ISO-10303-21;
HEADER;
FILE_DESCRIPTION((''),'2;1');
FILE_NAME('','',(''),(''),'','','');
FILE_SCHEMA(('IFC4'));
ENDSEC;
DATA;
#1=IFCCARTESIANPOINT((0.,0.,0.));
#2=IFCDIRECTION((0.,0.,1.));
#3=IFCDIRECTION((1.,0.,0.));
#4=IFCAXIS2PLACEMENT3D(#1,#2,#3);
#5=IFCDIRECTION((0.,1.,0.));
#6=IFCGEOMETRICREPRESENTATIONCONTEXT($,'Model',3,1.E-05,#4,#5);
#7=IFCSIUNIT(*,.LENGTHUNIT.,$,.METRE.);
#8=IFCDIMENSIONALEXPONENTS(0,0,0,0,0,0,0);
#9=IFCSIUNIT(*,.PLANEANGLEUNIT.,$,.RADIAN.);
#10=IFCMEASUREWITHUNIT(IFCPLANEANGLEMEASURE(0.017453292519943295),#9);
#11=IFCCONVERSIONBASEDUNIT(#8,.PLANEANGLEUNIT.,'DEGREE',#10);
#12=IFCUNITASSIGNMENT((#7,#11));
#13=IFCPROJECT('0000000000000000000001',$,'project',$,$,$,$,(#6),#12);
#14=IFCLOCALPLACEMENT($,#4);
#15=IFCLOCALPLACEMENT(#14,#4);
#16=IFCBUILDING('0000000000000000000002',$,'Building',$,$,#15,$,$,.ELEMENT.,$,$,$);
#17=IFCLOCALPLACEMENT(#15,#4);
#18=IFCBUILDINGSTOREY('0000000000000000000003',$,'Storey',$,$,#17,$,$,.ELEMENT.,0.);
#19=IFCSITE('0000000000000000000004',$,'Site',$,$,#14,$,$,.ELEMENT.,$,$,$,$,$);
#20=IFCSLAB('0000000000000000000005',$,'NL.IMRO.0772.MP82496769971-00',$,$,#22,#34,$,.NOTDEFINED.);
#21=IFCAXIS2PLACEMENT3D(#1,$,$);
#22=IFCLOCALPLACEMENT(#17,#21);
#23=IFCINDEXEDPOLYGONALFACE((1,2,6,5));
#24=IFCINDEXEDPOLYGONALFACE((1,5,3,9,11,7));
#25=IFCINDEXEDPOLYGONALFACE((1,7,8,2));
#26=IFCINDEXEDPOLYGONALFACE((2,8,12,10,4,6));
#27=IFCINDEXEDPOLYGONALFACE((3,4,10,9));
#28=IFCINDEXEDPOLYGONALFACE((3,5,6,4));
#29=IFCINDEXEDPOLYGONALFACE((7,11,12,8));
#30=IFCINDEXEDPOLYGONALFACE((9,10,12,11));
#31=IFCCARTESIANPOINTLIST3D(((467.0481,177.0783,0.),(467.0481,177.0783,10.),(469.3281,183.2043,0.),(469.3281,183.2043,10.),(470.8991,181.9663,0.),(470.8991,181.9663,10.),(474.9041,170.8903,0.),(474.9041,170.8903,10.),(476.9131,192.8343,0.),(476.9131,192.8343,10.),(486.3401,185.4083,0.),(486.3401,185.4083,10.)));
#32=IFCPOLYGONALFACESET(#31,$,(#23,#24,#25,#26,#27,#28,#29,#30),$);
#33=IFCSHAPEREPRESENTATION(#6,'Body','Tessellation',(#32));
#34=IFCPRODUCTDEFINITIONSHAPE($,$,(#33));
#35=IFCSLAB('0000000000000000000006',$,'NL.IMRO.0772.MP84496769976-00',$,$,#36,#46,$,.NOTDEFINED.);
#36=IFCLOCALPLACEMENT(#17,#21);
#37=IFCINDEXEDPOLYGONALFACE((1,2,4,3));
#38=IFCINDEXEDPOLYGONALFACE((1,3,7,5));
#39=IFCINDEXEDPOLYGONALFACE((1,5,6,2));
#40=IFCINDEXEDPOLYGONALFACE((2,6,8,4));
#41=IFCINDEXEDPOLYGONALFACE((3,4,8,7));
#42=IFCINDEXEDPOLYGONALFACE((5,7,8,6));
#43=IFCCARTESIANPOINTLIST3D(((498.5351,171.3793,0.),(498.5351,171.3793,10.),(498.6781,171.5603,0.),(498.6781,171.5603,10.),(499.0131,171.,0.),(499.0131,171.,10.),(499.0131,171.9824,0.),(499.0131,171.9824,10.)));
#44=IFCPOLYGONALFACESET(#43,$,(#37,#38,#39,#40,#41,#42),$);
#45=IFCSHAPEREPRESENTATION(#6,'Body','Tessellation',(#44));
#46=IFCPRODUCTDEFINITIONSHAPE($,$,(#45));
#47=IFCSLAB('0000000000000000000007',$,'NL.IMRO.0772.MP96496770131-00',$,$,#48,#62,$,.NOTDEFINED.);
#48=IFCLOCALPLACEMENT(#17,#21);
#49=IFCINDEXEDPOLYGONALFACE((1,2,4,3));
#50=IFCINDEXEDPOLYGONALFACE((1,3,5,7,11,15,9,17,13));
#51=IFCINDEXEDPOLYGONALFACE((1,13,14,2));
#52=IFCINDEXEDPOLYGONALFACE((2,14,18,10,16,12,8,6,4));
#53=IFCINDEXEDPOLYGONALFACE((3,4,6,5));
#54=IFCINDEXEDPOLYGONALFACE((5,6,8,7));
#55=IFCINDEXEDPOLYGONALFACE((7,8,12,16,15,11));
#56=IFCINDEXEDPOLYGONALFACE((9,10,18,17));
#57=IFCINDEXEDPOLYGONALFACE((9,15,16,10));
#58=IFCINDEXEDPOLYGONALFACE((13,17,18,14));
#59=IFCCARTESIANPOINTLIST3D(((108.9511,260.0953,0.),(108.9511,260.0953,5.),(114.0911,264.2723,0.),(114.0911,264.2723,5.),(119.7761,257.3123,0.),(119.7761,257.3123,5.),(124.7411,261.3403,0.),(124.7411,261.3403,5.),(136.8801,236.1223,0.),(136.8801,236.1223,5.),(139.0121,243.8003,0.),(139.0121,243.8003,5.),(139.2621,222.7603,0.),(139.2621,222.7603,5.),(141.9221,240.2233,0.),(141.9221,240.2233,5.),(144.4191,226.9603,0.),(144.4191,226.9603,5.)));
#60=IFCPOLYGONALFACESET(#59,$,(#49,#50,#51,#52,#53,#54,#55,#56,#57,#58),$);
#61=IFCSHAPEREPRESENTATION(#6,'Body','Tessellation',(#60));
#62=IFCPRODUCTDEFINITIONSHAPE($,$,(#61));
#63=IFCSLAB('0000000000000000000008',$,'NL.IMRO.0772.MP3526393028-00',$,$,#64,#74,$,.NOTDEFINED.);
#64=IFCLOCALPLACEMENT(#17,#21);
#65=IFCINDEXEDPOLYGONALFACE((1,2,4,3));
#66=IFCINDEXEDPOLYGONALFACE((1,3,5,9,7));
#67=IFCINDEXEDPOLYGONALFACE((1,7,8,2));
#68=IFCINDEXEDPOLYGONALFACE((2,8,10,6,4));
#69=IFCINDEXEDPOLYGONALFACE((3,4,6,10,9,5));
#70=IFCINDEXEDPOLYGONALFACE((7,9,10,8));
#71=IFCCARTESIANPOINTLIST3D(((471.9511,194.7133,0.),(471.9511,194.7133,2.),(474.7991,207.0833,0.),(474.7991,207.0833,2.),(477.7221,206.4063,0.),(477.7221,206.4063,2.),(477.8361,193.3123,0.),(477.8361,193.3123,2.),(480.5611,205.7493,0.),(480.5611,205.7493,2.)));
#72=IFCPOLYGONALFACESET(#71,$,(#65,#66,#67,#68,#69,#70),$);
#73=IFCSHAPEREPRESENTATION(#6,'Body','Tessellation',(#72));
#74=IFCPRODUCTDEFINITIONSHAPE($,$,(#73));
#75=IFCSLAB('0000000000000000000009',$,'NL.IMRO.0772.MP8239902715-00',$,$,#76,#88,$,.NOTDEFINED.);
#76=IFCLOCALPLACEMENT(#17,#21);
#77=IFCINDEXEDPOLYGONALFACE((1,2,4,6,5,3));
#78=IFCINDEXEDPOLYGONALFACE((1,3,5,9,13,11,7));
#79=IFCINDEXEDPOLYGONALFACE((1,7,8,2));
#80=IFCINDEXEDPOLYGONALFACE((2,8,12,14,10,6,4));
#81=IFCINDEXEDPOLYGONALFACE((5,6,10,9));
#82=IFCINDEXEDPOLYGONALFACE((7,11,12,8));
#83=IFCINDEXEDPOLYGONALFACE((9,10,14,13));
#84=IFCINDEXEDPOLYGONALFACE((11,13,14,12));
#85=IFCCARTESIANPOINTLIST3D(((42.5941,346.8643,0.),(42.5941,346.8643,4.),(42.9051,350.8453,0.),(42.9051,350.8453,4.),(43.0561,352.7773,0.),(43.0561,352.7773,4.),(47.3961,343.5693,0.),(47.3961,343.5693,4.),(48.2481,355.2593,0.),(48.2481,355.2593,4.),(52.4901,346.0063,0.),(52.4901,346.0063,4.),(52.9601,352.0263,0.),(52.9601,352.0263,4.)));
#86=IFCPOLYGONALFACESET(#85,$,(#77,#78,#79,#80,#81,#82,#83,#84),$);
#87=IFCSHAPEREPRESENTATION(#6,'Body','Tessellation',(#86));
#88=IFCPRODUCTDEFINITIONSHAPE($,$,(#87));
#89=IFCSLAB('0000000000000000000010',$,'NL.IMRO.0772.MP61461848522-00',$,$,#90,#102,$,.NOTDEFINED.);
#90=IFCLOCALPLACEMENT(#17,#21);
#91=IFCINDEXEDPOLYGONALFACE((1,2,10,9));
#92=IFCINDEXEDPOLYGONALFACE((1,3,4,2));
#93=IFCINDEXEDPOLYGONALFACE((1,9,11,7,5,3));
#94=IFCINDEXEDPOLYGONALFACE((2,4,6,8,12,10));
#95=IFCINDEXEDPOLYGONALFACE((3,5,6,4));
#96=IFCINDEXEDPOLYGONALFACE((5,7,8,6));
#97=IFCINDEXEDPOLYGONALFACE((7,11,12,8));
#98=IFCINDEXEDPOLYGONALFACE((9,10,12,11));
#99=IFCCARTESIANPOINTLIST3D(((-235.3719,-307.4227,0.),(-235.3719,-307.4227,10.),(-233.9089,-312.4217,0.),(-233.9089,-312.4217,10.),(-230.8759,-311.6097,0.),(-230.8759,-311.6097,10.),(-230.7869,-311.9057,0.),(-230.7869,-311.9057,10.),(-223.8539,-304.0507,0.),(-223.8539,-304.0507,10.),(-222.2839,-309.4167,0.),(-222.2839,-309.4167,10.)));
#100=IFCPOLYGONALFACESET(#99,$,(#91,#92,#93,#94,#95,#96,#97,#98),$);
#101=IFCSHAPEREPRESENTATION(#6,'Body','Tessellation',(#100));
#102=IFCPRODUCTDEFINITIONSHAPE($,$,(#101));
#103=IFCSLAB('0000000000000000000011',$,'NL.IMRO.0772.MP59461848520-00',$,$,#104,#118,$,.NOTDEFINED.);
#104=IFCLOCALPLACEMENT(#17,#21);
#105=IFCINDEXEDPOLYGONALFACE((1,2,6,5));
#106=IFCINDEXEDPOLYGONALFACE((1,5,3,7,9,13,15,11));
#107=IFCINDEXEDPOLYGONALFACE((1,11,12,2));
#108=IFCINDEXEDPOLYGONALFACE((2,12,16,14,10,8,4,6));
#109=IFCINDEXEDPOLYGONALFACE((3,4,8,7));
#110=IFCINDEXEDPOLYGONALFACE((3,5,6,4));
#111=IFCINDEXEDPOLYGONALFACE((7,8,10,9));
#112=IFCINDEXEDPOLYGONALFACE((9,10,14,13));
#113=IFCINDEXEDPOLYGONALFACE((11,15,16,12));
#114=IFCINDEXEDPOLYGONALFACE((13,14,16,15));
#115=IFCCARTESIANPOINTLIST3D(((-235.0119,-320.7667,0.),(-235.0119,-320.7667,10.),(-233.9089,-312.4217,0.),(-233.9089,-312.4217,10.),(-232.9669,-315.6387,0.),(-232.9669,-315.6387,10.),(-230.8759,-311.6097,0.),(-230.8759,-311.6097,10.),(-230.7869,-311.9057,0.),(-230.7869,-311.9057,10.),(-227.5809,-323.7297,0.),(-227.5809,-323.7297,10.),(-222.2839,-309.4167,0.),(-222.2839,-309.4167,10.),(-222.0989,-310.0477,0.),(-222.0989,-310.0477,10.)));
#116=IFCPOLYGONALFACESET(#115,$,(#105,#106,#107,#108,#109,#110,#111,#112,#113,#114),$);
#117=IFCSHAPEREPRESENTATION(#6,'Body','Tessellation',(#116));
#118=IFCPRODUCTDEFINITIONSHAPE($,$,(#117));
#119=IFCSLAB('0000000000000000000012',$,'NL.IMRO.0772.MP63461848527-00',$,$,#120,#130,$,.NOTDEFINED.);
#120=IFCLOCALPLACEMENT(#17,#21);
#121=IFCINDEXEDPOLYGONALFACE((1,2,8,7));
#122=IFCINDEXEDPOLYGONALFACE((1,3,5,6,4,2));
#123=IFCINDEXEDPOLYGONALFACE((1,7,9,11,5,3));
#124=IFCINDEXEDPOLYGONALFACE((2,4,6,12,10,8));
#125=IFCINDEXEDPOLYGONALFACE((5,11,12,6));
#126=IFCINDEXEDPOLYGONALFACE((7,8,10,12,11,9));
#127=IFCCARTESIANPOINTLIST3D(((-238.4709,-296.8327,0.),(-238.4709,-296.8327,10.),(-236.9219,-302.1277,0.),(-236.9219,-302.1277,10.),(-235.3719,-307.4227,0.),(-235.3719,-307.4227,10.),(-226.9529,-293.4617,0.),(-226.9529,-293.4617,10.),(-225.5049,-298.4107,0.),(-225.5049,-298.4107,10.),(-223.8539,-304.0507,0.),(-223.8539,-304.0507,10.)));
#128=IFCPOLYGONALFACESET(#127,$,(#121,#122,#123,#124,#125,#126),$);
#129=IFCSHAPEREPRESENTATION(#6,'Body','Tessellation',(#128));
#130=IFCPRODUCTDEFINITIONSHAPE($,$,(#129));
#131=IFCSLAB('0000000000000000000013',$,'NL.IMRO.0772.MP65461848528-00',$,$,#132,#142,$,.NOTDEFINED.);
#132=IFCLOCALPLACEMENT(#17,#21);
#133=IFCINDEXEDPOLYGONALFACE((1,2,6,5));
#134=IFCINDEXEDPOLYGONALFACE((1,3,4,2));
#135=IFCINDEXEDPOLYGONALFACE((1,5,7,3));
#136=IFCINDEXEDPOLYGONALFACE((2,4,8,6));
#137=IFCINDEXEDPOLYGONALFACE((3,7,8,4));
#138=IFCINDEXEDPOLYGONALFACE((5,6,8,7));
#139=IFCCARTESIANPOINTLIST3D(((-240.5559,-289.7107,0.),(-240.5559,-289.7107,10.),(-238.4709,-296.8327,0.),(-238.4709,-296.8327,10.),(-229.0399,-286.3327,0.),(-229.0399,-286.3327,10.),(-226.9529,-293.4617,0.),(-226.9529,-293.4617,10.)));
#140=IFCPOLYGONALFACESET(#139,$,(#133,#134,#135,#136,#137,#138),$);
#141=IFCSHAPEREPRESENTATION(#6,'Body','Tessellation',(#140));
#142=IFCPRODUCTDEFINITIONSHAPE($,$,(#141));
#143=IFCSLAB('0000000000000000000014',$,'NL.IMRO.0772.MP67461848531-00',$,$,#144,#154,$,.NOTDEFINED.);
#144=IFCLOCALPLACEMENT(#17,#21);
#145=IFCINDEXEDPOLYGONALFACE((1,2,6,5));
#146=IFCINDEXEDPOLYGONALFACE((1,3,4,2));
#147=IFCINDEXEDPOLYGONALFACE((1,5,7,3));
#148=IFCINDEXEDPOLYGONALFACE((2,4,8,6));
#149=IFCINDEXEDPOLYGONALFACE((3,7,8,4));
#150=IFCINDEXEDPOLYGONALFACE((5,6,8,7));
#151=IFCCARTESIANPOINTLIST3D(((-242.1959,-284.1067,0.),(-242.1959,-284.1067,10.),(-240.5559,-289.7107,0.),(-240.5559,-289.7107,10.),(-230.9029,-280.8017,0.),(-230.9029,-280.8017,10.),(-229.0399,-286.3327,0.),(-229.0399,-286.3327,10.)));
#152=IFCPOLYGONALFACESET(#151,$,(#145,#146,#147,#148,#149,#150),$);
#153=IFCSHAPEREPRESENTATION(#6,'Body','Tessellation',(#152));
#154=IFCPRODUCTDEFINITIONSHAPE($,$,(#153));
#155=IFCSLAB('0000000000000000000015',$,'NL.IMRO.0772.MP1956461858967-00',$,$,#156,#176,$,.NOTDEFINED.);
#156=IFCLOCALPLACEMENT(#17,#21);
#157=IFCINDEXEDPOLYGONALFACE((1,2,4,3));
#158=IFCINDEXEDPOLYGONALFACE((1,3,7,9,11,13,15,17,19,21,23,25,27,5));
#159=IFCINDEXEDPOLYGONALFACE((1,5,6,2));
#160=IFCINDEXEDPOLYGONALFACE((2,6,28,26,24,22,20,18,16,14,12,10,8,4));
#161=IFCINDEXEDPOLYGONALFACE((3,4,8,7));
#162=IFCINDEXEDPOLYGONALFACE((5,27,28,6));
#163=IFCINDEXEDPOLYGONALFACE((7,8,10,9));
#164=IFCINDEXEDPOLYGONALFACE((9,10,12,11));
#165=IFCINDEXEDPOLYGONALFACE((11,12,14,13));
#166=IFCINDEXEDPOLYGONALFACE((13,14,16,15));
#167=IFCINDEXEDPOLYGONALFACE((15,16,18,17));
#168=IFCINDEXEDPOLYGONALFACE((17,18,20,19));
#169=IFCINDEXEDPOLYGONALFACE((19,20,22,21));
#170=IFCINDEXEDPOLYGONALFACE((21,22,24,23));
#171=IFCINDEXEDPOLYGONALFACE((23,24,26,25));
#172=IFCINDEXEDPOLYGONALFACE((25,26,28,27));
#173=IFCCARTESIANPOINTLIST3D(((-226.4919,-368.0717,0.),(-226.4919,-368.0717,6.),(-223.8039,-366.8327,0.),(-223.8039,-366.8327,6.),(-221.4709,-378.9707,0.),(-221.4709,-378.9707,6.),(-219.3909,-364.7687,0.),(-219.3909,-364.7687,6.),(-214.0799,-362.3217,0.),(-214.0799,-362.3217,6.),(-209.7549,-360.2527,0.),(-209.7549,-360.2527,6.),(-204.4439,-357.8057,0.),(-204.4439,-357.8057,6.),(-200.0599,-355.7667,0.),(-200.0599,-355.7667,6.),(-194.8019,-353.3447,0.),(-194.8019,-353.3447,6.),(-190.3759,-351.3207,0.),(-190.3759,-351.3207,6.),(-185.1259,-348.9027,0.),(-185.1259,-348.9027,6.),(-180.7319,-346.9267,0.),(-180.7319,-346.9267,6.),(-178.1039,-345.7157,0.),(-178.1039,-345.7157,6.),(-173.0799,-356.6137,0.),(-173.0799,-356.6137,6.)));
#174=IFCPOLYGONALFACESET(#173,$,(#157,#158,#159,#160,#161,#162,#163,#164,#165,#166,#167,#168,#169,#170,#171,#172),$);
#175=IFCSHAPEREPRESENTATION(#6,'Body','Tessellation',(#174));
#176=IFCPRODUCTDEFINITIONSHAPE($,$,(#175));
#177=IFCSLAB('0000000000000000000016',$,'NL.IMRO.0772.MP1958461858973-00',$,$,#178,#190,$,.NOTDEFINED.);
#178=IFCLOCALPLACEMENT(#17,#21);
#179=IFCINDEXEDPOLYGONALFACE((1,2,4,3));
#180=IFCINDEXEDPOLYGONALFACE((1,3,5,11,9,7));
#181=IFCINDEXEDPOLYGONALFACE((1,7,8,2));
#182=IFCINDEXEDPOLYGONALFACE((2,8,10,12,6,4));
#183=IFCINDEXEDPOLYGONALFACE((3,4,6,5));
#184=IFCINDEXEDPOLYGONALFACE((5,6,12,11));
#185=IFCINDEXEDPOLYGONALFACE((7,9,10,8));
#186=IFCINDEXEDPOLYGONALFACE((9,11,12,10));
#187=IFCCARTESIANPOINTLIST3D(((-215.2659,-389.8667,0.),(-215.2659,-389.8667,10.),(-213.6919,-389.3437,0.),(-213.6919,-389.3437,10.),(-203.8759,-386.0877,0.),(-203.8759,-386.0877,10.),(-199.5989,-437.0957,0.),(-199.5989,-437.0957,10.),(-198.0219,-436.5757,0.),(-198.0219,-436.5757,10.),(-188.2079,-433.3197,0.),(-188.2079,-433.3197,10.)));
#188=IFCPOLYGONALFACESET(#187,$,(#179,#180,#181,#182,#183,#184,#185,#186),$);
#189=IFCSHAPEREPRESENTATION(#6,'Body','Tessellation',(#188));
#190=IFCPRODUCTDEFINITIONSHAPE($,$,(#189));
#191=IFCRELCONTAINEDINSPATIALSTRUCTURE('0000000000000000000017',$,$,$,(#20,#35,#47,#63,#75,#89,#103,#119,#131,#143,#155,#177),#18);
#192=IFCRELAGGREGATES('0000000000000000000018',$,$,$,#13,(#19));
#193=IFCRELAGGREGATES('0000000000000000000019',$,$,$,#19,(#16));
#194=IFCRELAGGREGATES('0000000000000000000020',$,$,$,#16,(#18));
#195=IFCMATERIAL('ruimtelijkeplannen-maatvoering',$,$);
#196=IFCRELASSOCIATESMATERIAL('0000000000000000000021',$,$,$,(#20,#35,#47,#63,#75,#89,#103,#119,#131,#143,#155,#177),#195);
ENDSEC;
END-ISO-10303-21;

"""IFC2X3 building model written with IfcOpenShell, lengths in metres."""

from ifc_helpers import new_model, entity, si_unit, converted_unit, direction, origin_with_axes, place, context, project, spatial, polyline, outline, extrude, material, element, save


model = new_model("IFC2X3")

# Units and contexts
model_context = context("Model", 3, precision=1e-05, world=origin_with_axes(), true_north=direction((0.0, 1.0, 0.0)))
ifc_project = project(units=[si_unit("LENGTHUNIT", "METRE"), converted_unit("PLANEANGLEUNIT", "DEGREE", entity("IfcPlaneAngleMeasure", 0.017453292519943295), si_unit("PLANEANGLEUNIT", "RADIAN"), dimensions=[0, 0, 0, 0, 0, 0, 0])], contexts=[model_context])

# Site, building, storey
site_placement = place(None, origin_with_axes())
site = spatial("IfcSite", under=ifc_project, at=site_placement, Name="Site", CompositionType="ELEMENT")
building_placement = place(site_placement, origin_with_axes())
building = spatial("IfcBuilding", under=site, at=building_placement, Name="Building", CompositionType="ELEMENT")
storey_placement = place(building_placement, origin_with_axes())
storey = spatial("IfcBuildingStorey", under=building, at=storey_placement, Name="Storey", CompositionType="ELEMENT", Elevation=0.0)

# Slabs
ifc_material = material(Name="ruimtelijkeplannen-maatvoering")
slab_1_placement = place(storey_placement, origin_with_axes())
element("IfcSlab", 1, at=slab_1_placement, inside=storey, material=ifc_material, Name="NL.IMRO.0772.MP82496769971-00", PredefinedType="NOTDEFINED", context=model_context, shape_type="SweptSolid", body=[
    extrude(outline(polyline([(467.0481, 177.0783), (470.8991, 181.9663), (469.3281, 183.2043), (476.9131, 192.8343), (486.3401, 185.4083), (474.9041, 170.8903), (467.0481, 177.0783)])), origin_with_axes(), (0.0, 0.0, 1.0), 10.0),
])
slab_2_placement = place(storey_placement, origin_with_axes())
element("IfcSlab", 2, at=slab_2_placement, inside=storey, material=ifc_material, Name="NL.IMRO.0772.MP84496769976-00", PredefinedType="NOTDEFINED", context=model_context, shape_type="SweptSolid", body=[
    extrude(outline(polyline([(498.5351, 171.3793), (498.6781, 171.5603), (499.0131, 171.9824), (499.0131, 171.0), (498.5351, 171.3793)])), origin_with_axes(), (0.0, 0.0, 1.0), 10.0),
])
slab_3_placement = place(storey_placement, origin_with_axes())
element("IfcSlab", 3, at=slab_3_placement, inside=storey, material=ifc_material, Name="NL.IMRO.0772.MP96496770131-00", PredefinedType="NOTDEFINED", context=model_context, shape_type="SweptSolid", body=[
    extrude(outline(polyline([(141.9221, 240.2233), (136.8801, 236.1223), (144.4191, 226.9603), (139.2621, 222.7603), (108.9511, 260.0953), (114.0911, 264.2723), (119.7761, 257.3123), (124.7411, 261.3403), (139.0121, 243.8003), (141.9221, 240.2233)])), origin_with_axes(), (0.0, 0.0, 1.0), 5.0),
])
slab_4_placement = place(storey_placement, origin_with_axes())
element("IfcSlab", 4, at=slab_4_placement, inside=storey, material=ifc_material, Name="NL.IMRO.0772.MP3526393028-00", PredefinedType="NOTDEFINED", context=model_context, shape_type="SweptSolid", body=[
    extrude(outline(polyline([(474.7991, 207.0833), (477.7221, 206.4063), (480.5611, 205.7493), (477.8361, 193.3123), (471.9511, 194.7133), (474.7991, 207.0833)])), origin_with_axes(), (0.0, 0.0, 1.0), 2.0),
])
slab_5_placement = place(storey_placement, origin_with_axes())
element("IfcSlab", 5, at=slab_5_placement, inside=storey, material=ifc_material, Name="NL.IMRO.0772.MP8239902715-00", PredefinedType="NOTDEFINED", context=model_context, shape_type="SweptSolid", body=[
    extrude(outline(polyline([(48.2481, 355.2593), (52.9601, 352.0263), (52.4901, 346.0063), (47.3961, 343.5693), (42.5941, 346.8643), (42.9051, 350.8453), (43.0561, 352.7773), (48.2481, 355.2593)])), origin_with_axes(), (0.0, 0.0, 1.0), 4.0),
])
slab_6_placement = place(storey_placement, origin_with_axes())
element("IfcSlab", 6, at=slab_6_placement, inside=storey, material=ifc_material, Name="NL.IMRO.0772.MP61461848522-00", PredefinedType="NOTDEFINED", context=model_context, shape_type="SweptSolid", body=[
    extrude(outline(polyline([(-233.9089, -312.4217), (-235.3719, -307.4227), (-223.8539, -304.0507), (-222.2839, -309.4167), (-230.7869, -311.9057), (-230.8759, -311.6097), (-233.9089, -312.4217)])), origin_with_axes(), (0.0, 0.0, 1.0), 10.0),
])
slab_7_placement = place(storey_placement, origin_with_axes())
element("IfcSlab", 7, at=slab_7_placement, inside=storey, material=ifc_material, Name="NL.IMRO.0772.MP59461848520-00", PredefinedType="NOTDEFINED", context=model_context, shape_type="SweptSolid", body=[
    extrude(outline(polyline([(-235.0119, -320.7667), (-232.9669, -315.6387), (-233.9089, -312.4217), (-230.8759, -311.6097), (-230.7869, -311.9057), (-222.2839, -309.4167), (-222.0989, -310.0477), (-227.5809, -323.7297), (-235.0119, -320.7667)])), origin_with_axes(), (0.0, 0.0, 1.0), 10.0),
])
slab_8_placement = place(storey_placement, origin_with_axes())
element("IfcSlab", 8, at=slab_8_placement, inside=storey, material=ifc_material, Name="NL.IMRO.0772.MP63461848527-00", PredefinedType="NOTDEFINED", context=model_context, shape_type="SweptSolid", body=[
    extrude(outline(polyline([(-236.9219, -302.1277), (-238.4709, -296.8327), (-226.9529, -293.4617), (-225.5049, -298.4107), (-223.8539, -304.0507), (-235.3719, -307.4227), (-236.9219, -302.1277)])), origin_with_axes(), (0.0, 0.0, 1.0), 10.0),
])
slab_9_placement = place(storey_placement, origin_with_axes())
element("IfcSlab", 9, at=slab_9_placement, inside=storey, material=ifc_material, Name="NL.IMRO.0772.MP65461848528-00", PredefinedType="NOTDEFINED", context=model_context, shape_type="SweptSolid", body=[
    extrude(outline(polyline([(-226.9529, -293.4617), (-238.4709, -296.8327), (-240.5559, -289.7107), (-229.0399, -286.3327), (-226.9529, -293.4617)])), origin_with_axes(), (0.0, 0.0, 1.0), 10.0),
])
slab_10_placement = place(storey_placement, origin_with_axes())
element("IfcSlab", 10, at=slab_10_placement, inside=storey, material=ifc_material, Name="NL.IMRO.0772.MP67461848531-00", PredefinedType="NOTDEFINED", context=model_context, shape_type="SweptSolid", body=[
    extrude(outline(polyline([(-242.1959, -284.1067), (-230.9029, -280.8017), (-229.0399, -286.3327), (-240.5559, -289.7107), (-242.1959, -284.1067)])), origin_with_axes(), (0.0, 0.0, 1.0), 10.0),
])
slab_11_placement = place(storey_placement, origin_with_axes())
element("IfcSlab", 11, at=slab_11_placement, inside=storey, material=ifc_material, Name="NL.IMRO.0772.MP1956461858967-00", PredefinedType="NOTDEFINED", context=model_context, shape_type="SweptSolid", body=[
    extrude(outline(polyline([(-221.4709, -378.9707), (-226.4919, -368.0717), (-223.8039, -366.8327), (-219.3909, -364.7687), (-214.0799, -362.3217), (-209.7549, -360.2527), (-204.4439, -357.8057), (-200.0599, -355.7667), (-194.8019, -353.3447), (-190.3759, -351.3207), (-185.1259, -348.9027), (-180.7319, -346.9267), (-178.1039, -345.7157), (-173.0799, -356.6137), (-221.4709, -378.9707)])), origin_with_axes(), (0.0, 0.0, 1.0), 6.0),
])
slab_12_placement = place(storey_placement, origin_with_axes())
element("IfcSlab", 12, at=slab_12_placement, inside=storey, material=ifc_material, Name="NL.IMRO.0772.MP1958461858973-00", PredefinedType="NOTDEFINED", context=model_context, shape_type="SweptSolid", body=[
    extrude(outline(polyline([(-198.0219, -436.5757), (-199.5989, -437.0957), (-215.2659, -389.8667), (-213.6919, -389.3437), (-203.8759, -386.0877), (-188.2079, -433.3197), (-198.0219, -436.5757)])), origin_with_axes(), (0.0, 0.0, 1.0), 10.0),
])

save(model, "model.ifc")
